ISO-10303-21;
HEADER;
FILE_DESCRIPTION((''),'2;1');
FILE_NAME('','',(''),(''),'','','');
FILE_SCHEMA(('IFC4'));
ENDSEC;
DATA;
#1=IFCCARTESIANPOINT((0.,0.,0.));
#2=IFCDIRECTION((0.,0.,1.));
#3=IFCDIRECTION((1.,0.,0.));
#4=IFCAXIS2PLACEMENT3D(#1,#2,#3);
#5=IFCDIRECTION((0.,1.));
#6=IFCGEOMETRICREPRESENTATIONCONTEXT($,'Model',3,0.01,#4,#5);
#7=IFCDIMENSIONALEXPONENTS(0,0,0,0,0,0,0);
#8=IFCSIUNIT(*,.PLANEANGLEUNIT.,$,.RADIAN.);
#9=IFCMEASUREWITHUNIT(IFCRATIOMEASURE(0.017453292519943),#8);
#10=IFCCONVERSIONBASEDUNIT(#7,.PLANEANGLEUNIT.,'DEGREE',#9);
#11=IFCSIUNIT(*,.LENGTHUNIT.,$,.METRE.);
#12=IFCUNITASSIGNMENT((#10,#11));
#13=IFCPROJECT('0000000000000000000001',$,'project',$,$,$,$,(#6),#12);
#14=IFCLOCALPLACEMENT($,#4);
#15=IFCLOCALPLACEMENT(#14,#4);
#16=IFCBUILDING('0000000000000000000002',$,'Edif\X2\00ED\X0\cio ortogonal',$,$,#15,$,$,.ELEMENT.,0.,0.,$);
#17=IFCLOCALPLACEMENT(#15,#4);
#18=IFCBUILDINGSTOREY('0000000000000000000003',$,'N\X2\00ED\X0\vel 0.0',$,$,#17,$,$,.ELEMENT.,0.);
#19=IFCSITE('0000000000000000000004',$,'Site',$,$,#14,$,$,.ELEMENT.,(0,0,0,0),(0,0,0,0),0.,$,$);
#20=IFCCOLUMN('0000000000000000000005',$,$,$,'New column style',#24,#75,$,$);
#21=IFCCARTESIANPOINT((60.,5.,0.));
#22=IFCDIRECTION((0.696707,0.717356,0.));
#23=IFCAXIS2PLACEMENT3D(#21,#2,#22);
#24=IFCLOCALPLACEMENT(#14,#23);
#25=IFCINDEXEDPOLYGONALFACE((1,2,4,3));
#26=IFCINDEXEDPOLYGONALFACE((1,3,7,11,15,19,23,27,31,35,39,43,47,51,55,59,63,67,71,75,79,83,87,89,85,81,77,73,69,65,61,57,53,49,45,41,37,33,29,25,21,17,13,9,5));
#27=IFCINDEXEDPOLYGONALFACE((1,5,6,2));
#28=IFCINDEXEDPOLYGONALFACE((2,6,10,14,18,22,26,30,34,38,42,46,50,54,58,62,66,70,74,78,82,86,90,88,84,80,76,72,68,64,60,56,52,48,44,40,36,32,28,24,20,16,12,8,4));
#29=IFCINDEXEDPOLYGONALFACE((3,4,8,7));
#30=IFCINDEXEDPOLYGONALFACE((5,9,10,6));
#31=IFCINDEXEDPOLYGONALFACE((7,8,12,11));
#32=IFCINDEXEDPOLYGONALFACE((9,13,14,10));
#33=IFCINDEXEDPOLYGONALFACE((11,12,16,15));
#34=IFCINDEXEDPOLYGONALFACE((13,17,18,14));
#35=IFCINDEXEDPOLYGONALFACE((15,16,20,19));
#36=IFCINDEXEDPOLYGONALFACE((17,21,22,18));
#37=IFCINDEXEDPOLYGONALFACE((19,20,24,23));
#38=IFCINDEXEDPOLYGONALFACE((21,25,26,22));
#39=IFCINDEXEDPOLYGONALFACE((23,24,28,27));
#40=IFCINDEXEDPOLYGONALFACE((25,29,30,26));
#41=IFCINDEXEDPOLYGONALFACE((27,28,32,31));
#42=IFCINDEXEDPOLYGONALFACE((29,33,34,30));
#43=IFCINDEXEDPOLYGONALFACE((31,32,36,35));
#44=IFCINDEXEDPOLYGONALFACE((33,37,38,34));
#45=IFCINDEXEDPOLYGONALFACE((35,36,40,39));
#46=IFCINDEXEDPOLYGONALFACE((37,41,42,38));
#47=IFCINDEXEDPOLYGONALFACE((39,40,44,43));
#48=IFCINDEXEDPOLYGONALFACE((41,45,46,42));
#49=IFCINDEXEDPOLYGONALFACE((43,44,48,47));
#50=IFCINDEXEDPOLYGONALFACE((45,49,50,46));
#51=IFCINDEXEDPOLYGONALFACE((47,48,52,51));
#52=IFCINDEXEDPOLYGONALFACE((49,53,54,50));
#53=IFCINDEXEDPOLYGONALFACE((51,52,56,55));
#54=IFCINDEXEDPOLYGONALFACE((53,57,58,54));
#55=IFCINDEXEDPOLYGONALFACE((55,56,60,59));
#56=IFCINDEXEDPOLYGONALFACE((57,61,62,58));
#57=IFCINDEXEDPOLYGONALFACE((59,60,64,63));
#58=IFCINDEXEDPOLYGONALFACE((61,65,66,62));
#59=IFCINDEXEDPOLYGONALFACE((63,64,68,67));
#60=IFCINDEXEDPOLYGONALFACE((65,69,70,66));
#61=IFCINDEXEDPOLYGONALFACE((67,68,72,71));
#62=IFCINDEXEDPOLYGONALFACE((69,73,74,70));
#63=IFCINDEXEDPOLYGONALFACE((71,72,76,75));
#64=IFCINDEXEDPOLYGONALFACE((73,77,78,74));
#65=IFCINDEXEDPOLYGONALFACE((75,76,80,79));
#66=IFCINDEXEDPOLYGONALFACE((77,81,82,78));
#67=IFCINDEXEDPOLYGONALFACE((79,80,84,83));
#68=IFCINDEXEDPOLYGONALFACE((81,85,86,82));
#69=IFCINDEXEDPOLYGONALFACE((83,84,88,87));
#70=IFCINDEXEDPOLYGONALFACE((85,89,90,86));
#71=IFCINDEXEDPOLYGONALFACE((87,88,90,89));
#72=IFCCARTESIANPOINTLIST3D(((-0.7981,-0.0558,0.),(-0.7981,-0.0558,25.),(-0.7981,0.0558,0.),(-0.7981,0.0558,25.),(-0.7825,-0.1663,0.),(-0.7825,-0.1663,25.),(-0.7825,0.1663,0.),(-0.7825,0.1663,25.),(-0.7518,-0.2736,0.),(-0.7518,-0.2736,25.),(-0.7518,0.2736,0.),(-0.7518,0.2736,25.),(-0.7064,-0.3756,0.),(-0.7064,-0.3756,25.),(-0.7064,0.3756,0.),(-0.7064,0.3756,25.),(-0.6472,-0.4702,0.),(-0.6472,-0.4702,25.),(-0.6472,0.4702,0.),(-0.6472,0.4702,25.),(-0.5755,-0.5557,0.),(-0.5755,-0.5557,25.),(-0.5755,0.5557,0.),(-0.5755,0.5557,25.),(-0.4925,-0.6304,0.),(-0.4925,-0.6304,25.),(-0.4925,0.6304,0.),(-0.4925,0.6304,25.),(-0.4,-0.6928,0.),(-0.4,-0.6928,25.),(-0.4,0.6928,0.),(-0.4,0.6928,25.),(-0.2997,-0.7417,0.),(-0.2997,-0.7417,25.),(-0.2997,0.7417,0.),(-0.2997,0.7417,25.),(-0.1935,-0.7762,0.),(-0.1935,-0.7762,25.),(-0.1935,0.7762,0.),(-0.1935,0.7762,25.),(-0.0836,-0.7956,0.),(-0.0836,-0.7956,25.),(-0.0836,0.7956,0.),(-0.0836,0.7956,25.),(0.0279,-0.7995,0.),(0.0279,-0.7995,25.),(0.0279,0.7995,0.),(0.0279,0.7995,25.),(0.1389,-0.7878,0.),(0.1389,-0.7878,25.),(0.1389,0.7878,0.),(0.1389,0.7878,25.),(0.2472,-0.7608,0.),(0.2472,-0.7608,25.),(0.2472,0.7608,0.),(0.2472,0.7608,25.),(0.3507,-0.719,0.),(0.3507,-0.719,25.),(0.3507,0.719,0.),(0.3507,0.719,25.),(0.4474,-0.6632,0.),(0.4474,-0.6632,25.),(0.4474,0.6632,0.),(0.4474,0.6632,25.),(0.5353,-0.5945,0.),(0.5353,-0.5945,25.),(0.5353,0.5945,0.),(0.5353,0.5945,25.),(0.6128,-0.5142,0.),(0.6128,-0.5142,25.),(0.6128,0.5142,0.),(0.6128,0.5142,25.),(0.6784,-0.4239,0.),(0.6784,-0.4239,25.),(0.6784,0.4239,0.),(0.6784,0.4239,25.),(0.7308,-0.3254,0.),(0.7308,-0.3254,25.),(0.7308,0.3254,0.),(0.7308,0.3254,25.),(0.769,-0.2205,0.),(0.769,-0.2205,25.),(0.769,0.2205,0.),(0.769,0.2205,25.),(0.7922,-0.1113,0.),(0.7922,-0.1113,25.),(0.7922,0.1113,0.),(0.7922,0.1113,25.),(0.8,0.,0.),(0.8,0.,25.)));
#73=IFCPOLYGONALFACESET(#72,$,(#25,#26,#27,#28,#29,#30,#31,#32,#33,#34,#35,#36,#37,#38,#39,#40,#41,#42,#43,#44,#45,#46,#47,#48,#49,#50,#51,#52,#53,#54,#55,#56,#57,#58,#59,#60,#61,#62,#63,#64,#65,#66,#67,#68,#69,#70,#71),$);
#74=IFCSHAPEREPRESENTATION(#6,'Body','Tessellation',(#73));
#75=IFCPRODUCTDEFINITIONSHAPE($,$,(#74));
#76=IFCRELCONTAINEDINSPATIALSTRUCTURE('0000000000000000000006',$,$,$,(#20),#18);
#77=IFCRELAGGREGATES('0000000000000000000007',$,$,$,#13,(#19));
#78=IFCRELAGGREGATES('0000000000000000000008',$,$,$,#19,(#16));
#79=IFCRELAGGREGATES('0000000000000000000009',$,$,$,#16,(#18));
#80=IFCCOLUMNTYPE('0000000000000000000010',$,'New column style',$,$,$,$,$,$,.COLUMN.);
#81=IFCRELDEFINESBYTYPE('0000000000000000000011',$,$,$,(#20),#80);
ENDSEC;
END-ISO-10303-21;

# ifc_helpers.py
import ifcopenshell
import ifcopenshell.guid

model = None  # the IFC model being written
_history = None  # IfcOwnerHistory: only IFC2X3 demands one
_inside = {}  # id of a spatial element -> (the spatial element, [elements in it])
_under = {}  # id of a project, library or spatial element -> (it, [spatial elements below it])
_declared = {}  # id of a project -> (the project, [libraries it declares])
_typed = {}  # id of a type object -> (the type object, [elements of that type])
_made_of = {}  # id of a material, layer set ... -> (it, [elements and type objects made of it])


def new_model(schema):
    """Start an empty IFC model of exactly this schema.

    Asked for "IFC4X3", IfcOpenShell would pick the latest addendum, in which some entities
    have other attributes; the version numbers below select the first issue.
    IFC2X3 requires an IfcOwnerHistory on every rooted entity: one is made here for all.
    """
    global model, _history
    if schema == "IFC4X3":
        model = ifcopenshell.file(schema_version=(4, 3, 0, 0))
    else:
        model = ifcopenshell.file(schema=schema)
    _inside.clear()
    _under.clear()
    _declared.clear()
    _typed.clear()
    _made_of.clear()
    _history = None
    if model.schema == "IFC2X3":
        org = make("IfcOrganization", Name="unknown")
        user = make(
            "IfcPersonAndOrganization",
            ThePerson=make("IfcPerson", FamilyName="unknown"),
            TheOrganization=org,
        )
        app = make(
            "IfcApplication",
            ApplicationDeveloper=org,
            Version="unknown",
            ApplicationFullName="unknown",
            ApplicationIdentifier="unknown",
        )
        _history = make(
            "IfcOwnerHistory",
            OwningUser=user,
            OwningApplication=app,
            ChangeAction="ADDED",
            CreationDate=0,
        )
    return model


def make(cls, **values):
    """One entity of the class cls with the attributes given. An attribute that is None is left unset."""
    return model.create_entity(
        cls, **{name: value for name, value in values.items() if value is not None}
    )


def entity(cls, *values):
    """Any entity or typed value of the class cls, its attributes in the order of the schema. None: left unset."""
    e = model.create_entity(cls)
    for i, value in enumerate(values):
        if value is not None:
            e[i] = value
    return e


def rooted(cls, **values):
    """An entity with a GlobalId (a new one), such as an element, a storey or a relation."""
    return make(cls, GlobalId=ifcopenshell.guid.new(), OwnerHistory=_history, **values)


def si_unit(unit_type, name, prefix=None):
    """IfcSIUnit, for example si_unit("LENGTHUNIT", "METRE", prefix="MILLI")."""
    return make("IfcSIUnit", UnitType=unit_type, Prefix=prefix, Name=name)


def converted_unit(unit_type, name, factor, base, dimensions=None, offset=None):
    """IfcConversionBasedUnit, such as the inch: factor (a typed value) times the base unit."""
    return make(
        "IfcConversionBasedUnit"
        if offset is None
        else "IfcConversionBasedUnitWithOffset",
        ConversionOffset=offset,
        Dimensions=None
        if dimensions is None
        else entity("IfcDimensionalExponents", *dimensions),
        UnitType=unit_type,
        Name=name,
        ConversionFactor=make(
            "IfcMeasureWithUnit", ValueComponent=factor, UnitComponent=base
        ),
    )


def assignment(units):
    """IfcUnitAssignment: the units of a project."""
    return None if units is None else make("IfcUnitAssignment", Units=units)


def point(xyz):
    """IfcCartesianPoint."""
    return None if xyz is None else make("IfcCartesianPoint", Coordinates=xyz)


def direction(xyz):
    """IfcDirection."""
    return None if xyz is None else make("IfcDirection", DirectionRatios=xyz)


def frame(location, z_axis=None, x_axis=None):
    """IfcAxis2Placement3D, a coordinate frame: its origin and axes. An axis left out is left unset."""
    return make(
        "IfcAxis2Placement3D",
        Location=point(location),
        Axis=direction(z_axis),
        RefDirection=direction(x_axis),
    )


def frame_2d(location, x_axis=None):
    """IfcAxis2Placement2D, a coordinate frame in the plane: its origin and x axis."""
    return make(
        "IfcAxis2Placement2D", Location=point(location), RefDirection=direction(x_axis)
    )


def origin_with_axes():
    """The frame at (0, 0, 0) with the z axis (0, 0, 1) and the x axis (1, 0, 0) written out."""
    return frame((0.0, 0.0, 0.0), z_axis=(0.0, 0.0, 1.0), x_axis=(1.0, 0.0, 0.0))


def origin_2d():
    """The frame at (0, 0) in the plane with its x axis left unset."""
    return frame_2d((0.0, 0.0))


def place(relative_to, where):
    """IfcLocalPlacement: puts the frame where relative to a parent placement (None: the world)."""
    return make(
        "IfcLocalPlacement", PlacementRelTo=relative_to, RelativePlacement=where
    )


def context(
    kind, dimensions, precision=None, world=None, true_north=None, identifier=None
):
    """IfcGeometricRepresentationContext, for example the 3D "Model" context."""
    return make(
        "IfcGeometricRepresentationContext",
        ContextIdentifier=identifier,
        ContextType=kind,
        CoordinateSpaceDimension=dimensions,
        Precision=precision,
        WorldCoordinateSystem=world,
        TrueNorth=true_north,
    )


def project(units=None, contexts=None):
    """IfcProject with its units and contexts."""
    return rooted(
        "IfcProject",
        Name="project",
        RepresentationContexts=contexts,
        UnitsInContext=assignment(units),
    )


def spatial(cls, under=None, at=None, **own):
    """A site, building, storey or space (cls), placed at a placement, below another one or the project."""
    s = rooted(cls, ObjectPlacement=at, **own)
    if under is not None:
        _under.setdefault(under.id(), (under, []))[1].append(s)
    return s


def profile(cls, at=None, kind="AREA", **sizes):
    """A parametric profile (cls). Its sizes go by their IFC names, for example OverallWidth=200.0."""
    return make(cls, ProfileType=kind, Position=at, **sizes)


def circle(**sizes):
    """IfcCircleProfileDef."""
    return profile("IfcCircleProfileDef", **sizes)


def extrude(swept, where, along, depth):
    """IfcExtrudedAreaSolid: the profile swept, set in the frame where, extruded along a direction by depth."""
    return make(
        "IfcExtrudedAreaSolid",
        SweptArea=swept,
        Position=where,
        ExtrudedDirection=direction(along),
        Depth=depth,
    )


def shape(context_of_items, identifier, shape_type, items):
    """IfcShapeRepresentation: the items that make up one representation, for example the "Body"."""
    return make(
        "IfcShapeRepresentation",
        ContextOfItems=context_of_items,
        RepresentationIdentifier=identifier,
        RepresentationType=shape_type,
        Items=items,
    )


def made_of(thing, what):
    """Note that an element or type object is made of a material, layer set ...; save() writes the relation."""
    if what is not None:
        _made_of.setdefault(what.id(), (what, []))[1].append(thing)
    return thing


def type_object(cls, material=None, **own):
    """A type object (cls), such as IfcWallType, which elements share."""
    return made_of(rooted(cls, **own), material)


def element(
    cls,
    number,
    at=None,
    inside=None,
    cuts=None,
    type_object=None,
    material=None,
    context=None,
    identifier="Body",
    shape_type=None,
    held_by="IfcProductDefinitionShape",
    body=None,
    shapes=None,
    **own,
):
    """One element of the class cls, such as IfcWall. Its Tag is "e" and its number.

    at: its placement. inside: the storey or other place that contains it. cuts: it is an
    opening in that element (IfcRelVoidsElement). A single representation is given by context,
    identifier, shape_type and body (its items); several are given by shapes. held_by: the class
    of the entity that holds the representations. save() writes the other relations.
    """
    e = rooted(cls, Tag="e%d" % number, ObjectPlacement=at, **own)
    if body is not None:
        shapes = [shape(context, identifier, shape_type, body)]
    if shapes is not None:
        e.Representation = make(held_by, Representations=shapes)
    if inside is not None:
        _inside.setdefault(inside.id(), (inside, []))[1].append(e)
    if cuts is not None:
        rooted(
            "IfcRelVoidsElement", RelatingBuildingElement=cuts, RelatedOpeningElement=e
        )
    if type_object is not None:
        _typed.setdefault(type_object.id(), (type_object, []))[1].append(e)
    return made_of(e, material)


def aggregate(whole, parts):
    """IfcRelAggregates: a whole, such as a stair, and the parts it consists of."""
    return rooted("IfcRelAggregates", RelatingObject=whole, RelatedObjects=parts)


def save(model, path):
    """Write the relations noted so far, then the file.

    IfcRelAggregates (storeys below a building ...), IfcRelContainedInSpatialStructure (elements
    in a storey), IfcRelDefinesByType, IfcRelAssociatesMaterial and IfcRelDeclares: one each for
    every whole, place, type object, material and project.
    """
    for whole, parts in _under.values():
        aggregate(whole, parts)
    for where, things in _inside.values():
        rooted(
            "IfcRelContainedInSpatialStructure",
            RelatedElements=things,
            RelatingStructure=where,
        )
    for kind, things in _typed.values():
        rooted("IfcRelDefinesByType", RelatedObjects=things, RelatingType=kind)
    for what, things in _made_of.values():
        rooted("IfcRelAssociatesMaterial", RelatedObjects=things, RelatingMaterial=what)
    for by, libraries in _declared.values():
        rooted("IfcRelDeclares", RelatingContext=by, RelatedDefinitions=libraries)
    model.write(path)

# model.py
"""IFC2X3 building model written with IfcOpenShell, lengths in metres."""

from ifc_helpers import new_model, entity, si_unit, converted_unit, direction, frame, origin_with_axes, origin_2d, place, context, project, spatial, circle, extrude, type_object, element, save


model = new_model("IFC2X3")

# Units and contexts
model_context = context("Model", 3, precision=0.01, world=origin_with_axes(), true_north=direction((0.0, 1.0)))
ifc_project = project(units=[converted_unit("PLANEANGLEUNIT", "DEGREE", entity("IfcRatioMeasure", 0.017453292519943), si_unit("PLANEANGLEUNIT", "RADIAN"), dimensions=[0, 0, 0, 0, 0, 0, 0]), si_unit("LENGTHUNIT", "METRE")], contexts=[model_context])

# Site, building, storey
site_placement = place(None, origin_with_axes())
site = spatial("IfcSite", under=ifc_project, at=site_placement, Name="Site", CompositionType="ELEMENT", RefLatitude=(0, 0, 0, 0), RefLongitude=(0, 0, 0, 0), RefElevation=0.0)
building_placement = place(site_placement, origin_with_axes())
building = spatial("IfcBuilding", under=site, at=building_placement, Name="Edifício ortogonal", CompositionType="ELEMENT", ElevationOfRefHeight=0.0, ElevationOfTerrain=0.0)
storey_placement = place(building_placement, origin_with_axes())
storey = spatial("IfcBuildingStorey", under=building, at=storey_placement, Name="Nível 0.0", CompositionType="ELEMENT", Elevation=0.0)

# Column
column_type = type_object("IfcColumnType", Name="New column style", PredefinedType="COLUMN")
for number, where, z_axis, x_axis in (
    (1, (60.0, 5.0, 0.0), (0.0, 0.0, 1.0), (0.696707, 0.717356, 0.0)),
):
    element("IfcColumn", number, at=place(site_placement, frame(where, z_axis=z_axis, x_axis=x_axis)), inside=storey, type_object=column_type, ObjectType="New column style", context=model_context, shape_type="SweptSolid", body=[
        extrude(circle(Radius=0.8, at=origin_2d()), origin_with_axes(), (0.0, 0.0, 1.0), 25.0),
    ])

save(model, "model.ifc")
